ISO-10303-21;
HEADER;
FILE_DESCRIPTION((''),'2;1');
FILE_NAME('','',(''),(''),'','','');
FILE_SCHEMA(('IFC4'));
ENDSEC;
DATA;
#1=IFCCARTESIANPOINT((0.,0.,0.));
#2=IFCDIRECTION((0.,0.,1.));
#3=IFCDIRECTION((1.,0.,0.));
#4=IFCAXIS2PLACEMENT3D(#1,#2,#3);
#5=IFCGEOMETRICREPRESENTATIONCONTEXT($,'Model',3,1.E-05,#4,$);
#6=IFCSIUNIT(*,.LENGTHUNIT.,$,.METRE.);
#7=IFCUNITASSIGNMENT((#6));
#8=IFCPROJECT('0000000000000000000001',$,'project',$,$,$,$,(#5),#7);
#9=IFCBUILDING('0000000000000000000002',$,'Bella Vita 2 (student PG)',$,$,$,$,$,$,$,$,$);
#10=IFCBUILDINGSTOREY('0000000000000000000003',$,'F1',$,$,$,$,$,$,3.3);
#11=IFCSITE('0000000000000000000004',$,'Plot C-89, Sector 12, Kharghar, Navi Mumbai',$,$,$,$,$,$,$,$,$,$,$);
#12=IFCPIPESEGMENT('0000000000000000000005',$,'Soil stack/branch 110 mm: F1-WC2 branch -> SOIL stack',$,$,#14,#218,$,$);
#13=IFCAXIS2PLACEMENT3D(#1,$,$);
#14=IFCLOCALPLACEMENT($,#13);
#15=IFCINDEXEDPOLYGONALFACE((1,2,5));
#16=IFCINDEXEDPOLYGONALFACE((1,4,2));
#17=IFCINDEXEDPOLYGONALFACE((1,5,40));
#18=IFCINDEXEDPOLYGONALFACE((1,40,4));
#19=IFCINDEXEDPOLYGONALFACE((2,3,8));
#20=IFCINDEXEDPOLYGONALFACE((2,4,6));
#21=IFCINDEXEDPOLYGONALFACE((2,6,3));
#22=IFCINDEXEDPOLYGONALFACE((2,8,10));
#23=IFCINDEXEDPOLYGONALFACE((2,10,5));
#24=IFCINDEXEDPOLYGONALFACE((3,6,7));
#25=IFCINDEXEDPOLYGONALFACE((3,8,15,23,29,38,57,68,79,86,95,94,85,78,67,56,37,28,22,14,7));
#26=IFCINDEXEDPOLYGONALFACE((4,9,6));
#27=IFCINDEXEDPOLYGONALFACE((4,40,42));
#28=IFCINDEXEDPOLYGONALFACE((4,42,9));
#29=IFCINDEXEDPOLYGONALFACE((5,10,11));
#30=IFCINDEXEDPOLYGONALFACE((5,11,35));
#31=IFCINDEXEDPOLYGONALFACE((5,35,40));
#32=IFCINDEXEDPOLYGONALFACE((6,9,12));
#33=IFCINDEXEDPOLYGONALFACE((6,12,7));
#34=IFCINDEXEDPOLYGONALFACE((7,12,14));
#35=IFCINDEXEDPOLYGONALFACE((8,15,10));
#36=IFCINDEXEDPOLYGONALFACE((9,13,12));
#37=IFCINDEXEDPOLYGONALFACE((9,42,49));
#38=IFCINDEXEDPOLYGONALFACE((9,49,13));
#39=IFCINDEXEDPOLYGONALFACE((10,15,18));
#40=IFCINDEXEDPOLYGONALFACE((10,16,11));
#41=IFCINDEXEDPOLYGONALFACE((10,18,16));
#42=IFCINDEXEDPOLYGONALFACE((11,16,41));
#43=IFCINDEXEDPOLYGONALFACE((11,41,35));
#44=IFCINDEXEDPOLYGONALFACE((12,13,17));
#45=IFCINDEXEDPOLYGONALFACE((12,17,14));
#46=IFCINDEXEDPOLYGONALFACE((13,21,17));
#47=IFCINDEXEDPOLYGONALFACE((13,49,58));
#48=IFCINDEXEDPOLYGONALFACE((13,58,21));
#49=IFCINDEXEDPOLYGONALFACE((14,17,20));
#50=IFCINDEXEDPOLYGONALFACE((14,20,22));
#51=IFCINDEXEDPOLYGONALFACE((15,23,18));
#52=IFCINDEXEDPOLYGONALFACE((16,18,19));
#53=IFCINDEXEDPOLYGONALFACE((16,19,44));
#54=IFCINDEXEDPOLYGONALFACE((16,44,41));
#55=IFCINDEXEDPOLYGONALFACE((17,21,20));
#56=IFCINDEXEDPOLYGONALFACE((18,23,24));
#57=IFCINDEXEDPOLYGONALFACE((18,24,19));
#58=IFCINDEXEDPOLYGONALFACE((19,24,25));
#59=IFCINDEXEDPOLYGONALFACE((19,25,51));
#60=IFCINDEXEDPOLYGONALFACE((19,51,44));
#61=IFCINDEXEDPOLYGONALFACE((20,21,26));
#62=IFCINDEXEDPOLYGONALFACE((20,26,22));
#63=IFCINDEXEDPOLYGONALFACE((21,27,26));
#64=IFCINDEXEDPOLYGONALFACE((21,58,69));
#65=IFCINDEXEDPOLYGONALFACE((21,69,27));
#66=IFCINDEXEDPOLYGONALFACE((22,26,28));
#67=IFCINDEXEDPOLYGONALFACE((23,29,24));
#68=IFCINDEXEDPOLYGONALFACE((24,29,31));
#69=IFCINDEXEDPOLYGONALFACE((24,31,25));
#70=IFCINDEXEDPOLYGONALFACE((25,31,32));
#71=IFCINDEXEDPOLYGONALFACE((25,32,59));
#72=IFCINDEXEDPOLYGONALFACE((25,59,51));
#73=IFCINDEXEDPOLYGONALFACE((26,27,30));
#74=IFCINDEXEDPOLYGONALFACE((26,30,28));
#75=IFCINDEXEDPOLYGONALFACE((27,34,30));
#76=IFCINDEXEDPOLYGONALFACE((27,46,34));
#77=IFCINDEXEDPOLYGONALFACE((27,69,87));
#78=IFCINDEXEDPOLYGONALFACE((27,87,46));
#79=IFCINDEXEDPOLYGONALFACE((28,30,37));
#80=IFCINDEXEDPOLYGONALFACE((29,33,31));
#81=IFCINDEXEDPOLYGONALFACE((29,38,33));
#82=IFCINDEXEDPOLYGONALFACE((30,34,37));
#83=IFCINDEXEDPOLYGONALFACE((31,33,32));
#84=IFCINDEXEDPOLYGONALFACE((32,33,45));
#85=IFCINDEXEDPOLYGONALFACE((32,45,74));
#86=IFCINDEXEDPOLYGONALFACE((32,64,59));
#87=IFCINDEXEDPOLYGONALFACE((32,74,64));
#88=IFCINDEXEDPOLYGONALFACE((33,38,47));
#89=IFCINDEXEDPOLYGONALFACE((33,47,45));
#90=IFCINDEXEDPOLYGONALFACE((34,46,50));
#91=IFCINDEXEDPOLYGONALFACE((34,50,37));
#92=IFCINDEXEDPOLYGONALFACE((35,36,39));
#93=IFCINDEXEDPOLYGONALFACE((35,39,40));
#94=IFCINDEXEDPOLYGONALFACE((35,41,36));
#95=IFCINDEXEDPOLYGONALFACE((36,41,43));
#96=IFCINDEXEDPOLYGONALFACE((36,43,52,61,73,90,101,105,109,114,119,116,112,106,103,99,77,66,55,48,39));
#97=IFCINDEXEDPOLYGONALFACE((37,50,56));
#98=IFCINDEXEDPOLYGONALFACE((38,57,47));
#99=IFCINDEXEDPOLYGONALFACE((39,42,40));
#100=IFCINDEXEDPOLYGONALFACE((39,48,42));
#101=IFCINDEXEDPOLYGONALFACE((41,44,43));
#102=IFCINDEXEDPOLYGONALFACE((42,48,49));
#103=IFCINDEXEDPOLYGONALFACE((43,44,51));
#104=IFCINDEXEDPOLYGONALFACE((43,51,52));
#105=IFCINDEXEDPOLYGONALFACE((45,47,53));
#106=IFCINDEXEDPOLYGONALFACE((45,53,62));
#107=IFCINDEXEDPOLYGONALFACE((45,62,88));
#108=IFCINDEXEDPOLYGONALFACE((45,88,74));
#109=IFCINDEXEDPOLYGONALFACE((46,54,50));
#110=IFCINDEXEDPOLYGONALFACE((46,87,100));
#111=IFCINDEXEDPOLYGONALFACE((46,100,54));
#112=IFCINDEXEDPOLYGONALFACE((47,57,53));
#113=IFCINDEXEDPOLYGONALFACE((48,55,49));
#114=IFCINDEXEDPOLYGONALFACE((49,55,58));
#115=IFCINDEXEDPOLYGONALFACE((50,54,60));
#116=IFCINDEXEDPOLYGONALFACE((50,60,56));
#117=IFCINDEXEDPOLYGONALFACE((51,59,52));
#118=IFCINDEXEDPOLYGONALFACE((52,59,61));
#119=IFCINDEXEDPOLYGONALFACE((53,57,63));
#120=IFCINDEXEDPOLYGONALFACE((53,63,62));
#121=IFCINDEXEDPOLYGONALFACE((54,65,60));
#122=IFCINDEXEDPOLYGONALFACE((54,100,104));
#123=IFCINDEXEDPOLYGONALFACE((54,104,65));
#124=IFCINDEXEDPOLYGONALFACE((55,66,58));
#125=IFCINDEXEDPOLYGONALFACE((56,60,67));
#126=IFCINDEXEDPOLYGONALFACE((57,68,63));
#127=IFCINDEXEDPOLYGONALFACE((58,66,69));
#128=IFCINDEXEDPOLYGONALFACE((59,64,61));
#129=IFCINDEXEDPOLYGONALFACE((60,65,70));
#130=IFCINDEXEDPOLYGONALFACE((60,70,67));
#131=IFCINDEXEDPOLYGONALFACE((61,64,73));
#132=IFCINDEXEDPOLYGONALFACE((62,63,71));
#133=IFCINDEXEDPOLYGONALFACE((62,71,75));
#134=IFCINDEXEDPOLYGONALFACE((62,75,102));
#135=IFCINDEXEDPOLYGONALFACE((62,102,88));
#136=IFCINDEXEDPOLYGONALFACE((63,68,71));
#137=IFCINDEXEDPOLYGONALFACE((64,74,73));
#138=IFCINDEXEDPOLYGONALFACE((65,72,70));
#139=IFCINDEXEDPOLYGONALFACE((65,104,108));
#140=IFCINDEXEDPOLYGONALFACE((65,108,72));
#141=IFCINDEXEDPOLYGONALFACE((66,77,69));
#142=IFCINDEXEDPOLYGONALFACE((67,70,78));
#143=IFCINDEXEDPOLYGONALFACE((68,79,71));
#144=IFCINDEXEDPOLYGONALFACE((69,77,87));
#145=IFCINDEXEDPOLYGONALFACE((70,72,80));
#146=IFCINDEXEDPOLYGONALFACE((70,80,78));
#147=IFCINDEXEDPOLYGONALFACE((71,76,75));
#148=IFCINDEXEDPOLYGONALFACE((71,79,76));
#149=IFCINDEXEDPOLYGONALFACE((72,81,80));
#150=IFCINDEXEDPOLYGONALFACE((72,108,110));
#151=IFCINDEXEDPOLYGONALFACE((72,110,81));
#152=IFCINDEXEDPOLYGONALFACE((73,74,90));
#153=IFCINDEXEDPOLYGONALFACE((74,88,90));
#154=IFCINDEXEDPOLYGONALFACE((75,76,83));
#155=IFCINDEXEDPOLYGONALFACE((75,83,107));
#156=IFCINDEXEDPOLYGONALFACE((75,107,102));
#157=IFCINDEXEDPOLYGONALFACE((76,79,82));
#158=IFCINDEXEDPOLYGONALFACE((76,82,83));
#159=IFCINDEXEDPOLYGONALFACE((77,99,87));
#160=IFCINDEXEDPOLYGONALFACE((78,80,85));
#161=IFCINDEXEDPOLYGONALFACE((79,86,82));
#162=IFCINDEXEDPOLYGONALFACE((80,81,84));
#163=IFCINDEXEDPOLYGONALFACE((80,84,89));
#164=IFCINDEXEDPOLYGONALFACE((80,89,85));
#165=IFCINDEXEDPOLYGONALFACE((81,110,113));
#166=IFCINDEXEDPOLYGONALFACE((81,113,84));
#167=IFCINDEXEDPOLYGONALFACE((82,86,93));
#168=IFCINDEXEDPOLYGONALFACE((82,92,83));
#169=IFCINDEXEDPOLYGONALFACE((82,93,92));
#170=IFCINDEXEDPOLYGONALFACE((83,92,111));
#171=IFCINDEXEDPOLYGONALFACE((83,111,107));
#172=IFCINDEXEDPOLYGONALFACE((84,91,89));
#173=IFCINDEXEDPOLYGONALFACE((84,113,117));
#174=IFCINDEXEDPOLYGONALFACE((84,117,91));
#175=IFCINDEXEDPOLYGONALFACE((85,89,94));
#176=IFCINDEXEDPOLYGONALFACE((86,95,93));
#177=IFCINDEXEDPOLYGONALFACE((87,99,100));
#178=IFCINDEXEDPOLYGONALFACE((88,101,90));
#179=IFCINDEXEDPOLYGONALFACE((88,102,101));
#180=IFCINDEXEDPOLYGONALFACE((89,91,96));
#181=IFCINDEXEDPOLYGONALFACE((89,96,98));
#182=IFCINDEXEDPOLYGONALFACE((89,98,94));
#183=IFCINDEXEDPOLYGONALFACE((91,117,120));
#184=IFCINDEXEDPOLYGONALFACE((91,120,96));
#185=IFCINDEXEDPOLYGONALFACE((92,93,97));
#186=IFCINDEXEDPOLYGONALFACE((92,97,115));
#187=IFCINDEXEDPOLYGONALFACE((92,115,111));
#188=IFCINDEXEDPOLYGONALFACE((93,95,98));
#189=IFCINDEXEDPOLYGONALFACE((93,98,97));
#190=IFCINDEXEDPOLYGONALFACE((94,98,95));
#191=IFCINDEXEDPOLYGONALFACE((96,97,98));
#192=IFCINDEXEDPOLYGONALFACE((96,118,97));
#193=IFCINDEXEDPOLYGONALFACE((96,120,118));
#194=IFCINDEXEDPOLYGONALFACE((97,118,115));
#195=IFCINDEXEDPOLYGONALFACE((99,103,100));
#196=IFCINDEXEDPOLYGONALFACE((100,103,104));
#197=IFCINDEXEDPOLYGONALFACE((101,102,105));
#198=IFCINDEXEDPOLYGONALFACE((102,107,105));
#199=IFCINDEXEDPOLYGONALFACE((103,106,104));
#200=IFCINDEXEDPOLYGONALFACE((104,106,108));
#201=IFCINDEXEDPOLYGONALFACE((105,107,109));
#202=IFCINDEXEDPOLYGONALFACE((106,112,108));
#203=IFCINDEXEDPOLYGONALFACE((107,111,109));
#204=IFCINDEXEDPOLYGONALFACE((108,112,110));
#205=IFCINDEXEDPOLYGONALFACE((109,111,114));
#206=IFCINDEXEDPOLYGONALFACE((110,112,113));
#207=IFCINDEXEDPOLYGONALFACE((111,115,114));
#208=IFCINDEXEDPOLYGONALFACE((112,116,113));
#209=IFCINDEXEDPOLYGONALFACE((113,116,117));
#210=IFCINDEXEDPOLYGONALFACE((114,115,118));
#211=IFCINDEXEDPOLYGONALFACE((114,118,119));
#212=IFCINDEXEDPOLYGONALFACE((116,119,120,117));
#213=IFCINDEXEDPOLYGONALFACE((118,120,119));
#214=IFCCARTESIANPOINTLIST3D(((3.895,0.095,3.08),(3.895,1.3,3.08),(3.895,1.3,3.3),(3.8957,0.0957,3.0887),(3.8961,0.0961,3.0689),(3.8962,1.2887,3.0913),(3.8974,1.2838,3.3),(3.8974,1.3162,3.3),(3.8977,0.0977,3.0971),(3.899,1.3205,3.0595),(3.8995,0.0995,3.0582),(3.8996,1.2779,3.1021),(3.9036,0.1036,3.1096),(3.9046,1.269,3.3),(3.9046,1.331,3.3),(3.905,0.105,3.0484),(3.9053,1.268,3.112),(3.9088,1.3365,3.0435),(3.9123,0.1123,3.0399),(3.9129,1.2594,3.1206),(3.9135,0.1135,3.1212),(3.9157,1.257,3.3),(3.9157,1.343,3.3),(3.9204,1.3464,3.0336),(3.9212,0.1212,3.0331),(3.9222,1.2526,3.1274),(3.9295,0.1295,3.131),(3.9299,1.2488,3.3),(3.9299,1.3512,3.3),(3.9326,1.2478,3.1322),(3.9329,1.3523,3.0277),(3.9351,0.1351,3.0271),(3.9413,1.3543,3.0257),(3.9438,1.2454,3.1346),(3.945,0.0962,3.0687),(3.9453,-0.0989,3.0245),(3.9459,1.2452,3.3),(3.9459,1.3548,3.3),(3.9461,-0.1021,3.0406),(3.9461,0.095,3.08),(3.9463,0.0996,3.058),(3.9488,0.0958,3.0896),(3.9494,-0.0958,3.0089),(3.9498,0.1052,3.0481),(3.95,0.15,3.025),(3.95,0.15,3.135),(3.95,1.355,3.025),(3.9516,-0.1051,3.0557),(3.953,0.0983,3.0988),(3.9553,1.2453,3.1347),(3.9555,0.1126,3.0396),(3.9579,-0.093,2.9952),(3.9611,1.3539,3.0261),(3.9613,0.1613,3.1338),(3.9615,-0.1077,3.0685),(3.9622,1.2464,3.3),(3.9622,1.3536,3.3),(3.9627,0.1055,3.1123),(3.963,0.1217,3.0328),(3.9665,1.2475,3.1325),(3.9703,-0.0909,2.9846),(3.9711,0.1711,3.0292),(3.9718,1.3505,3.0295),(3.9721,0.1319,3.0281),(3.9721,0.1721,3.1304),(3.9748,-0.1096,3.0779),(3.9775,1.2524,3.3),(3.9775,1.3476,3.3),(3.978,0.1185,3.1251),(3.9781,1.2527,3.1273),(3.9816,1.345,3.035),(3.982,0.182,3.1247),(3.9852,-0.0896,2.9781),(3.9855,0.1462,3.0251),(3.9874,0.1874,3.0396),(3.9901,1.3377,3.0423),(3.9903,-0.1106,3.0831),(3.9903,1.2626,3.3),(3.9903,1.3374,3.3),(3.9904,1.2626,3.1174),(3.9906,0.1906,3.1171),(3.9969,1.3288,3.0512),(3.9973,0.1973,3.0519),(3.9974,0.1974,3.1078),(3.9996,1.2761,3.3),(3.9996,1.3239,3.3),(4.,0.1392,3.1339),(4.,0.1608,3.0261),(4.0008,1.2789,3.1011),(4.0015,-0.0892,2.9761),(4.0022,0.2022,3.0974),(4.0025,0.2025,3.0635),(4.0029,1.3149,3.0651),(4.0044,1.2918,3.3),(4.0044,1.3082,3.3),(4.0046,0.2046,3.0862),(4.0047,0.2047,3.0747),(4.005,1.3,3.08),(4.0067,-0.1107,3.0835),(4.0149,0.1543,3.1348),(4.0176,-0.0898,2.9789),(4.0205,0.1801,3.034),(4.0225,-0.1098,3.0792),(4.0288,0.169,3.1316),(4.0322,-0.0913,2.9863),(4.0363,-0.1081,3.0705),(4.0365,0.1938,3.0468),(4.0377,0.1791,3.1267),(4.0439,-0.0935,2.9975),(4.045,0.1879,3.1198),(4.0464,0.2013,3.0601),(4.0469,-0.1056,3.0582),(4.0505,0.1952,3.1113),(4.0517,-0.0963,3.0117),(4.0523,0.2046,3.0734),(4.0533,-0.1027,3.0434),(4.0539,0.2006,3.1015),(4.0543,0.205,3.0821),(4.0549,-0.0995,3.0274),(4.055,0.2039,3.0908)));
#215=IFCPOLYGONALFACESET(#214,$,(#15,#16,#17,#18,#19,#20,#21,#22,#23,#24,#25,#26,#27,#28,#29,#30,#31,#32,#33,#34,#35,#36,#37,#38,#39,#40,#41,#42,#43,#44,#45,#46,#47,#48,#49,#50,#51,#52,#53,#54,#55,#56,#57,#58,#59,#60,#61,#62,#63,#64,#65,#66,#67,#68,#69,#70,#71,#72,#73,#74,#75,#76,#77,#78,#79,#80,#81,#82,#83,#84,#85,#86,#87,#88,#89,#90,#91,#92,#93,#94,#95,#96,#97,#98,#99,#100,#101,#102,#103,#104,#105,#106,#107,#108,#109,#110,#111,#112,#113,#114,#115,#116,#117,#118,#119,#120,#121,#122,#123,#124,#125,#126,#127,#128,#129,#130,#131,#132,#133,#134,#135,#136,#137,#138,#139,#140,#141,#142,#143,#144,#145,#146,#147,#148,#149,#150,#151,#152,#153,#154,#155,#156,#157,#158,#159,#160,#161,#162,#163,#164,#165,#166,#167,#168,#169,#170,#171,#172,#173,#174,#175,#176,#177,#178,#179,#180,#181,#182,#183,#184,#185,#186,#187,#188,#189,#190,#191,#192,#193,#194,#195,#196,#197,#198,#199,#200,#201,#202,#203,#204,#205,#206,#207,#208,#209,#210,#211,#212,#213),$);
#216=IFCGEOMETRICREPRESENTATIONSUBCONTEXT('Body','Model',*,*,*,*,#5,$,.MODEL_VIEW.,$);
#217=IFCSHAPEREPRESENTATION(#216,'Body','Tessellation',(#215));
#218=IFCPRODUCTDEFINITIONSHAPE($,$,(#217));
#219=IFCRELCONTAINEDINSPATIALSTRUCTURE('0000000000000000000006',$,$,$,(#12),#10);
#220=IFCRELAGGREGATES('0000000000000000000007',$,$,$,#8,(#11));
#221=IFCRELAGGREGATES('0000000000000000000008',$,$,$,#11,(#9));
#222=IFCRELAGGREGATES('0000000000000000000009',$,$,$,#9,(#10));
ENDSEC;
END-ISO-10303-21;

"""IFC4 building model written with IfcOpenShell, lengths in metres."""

from ifc_helpers import new_model, entity, si_unit, origin, origin_with_axes, place, context, subcontext, project, spatial, element, save


model = new_model("IFC4")

# Units and contexts
model_context = context("Model", 3, precision=1e-05, world=origin_with_axes())
body_context = subcontext(model_context, "Body", "Model", "MODEL_VIEW")
ifc_project = project(units=[si_unit("LENGTHUNIT", "METRE")], contexts=[model_context])

# Site, building, storey
site = spatial("IfcSite", under=ifc_project, Name="Plot C-89, Sector 12, Kharghar, Navi Mumbai")
building = spatial("IfcBuilding", under=site, Name="Bella Vita 2 (student PG)")
storey = spatial("IfcBuildingStorey", under=building, Name="F1", Elevation=3.3)

# Pipe segment
pipe_segment_1_placement = place(None, origin())
element("IfcPipeSegment", 1, at=pipe_segment_1_placement, inside=storey, Name="Soil stack/branch 110 mm: F1-WC2 branch -> SOIL stack", context=body_context, shape_type="AdvancedSweptSolid", body=[
    entity("IfcSweptDiskSolid", entity("IfcPolyline", [entity("IfcCartesianPoint", [3.95, 1.3, 3.3]), entity("IfcCartesianPoint", [3.95, 1.3, 3.08]), entity("IfcCartesianPoint", [3.95, 0.15, 3.08]), entity("IfcCartesianPoint", [4.0, 0.15, 3.08]), entity("IfcCartesianPoint", [4.0, -0.1, 3.03])]), 0.055),
])

save(model, "model.ifc")
